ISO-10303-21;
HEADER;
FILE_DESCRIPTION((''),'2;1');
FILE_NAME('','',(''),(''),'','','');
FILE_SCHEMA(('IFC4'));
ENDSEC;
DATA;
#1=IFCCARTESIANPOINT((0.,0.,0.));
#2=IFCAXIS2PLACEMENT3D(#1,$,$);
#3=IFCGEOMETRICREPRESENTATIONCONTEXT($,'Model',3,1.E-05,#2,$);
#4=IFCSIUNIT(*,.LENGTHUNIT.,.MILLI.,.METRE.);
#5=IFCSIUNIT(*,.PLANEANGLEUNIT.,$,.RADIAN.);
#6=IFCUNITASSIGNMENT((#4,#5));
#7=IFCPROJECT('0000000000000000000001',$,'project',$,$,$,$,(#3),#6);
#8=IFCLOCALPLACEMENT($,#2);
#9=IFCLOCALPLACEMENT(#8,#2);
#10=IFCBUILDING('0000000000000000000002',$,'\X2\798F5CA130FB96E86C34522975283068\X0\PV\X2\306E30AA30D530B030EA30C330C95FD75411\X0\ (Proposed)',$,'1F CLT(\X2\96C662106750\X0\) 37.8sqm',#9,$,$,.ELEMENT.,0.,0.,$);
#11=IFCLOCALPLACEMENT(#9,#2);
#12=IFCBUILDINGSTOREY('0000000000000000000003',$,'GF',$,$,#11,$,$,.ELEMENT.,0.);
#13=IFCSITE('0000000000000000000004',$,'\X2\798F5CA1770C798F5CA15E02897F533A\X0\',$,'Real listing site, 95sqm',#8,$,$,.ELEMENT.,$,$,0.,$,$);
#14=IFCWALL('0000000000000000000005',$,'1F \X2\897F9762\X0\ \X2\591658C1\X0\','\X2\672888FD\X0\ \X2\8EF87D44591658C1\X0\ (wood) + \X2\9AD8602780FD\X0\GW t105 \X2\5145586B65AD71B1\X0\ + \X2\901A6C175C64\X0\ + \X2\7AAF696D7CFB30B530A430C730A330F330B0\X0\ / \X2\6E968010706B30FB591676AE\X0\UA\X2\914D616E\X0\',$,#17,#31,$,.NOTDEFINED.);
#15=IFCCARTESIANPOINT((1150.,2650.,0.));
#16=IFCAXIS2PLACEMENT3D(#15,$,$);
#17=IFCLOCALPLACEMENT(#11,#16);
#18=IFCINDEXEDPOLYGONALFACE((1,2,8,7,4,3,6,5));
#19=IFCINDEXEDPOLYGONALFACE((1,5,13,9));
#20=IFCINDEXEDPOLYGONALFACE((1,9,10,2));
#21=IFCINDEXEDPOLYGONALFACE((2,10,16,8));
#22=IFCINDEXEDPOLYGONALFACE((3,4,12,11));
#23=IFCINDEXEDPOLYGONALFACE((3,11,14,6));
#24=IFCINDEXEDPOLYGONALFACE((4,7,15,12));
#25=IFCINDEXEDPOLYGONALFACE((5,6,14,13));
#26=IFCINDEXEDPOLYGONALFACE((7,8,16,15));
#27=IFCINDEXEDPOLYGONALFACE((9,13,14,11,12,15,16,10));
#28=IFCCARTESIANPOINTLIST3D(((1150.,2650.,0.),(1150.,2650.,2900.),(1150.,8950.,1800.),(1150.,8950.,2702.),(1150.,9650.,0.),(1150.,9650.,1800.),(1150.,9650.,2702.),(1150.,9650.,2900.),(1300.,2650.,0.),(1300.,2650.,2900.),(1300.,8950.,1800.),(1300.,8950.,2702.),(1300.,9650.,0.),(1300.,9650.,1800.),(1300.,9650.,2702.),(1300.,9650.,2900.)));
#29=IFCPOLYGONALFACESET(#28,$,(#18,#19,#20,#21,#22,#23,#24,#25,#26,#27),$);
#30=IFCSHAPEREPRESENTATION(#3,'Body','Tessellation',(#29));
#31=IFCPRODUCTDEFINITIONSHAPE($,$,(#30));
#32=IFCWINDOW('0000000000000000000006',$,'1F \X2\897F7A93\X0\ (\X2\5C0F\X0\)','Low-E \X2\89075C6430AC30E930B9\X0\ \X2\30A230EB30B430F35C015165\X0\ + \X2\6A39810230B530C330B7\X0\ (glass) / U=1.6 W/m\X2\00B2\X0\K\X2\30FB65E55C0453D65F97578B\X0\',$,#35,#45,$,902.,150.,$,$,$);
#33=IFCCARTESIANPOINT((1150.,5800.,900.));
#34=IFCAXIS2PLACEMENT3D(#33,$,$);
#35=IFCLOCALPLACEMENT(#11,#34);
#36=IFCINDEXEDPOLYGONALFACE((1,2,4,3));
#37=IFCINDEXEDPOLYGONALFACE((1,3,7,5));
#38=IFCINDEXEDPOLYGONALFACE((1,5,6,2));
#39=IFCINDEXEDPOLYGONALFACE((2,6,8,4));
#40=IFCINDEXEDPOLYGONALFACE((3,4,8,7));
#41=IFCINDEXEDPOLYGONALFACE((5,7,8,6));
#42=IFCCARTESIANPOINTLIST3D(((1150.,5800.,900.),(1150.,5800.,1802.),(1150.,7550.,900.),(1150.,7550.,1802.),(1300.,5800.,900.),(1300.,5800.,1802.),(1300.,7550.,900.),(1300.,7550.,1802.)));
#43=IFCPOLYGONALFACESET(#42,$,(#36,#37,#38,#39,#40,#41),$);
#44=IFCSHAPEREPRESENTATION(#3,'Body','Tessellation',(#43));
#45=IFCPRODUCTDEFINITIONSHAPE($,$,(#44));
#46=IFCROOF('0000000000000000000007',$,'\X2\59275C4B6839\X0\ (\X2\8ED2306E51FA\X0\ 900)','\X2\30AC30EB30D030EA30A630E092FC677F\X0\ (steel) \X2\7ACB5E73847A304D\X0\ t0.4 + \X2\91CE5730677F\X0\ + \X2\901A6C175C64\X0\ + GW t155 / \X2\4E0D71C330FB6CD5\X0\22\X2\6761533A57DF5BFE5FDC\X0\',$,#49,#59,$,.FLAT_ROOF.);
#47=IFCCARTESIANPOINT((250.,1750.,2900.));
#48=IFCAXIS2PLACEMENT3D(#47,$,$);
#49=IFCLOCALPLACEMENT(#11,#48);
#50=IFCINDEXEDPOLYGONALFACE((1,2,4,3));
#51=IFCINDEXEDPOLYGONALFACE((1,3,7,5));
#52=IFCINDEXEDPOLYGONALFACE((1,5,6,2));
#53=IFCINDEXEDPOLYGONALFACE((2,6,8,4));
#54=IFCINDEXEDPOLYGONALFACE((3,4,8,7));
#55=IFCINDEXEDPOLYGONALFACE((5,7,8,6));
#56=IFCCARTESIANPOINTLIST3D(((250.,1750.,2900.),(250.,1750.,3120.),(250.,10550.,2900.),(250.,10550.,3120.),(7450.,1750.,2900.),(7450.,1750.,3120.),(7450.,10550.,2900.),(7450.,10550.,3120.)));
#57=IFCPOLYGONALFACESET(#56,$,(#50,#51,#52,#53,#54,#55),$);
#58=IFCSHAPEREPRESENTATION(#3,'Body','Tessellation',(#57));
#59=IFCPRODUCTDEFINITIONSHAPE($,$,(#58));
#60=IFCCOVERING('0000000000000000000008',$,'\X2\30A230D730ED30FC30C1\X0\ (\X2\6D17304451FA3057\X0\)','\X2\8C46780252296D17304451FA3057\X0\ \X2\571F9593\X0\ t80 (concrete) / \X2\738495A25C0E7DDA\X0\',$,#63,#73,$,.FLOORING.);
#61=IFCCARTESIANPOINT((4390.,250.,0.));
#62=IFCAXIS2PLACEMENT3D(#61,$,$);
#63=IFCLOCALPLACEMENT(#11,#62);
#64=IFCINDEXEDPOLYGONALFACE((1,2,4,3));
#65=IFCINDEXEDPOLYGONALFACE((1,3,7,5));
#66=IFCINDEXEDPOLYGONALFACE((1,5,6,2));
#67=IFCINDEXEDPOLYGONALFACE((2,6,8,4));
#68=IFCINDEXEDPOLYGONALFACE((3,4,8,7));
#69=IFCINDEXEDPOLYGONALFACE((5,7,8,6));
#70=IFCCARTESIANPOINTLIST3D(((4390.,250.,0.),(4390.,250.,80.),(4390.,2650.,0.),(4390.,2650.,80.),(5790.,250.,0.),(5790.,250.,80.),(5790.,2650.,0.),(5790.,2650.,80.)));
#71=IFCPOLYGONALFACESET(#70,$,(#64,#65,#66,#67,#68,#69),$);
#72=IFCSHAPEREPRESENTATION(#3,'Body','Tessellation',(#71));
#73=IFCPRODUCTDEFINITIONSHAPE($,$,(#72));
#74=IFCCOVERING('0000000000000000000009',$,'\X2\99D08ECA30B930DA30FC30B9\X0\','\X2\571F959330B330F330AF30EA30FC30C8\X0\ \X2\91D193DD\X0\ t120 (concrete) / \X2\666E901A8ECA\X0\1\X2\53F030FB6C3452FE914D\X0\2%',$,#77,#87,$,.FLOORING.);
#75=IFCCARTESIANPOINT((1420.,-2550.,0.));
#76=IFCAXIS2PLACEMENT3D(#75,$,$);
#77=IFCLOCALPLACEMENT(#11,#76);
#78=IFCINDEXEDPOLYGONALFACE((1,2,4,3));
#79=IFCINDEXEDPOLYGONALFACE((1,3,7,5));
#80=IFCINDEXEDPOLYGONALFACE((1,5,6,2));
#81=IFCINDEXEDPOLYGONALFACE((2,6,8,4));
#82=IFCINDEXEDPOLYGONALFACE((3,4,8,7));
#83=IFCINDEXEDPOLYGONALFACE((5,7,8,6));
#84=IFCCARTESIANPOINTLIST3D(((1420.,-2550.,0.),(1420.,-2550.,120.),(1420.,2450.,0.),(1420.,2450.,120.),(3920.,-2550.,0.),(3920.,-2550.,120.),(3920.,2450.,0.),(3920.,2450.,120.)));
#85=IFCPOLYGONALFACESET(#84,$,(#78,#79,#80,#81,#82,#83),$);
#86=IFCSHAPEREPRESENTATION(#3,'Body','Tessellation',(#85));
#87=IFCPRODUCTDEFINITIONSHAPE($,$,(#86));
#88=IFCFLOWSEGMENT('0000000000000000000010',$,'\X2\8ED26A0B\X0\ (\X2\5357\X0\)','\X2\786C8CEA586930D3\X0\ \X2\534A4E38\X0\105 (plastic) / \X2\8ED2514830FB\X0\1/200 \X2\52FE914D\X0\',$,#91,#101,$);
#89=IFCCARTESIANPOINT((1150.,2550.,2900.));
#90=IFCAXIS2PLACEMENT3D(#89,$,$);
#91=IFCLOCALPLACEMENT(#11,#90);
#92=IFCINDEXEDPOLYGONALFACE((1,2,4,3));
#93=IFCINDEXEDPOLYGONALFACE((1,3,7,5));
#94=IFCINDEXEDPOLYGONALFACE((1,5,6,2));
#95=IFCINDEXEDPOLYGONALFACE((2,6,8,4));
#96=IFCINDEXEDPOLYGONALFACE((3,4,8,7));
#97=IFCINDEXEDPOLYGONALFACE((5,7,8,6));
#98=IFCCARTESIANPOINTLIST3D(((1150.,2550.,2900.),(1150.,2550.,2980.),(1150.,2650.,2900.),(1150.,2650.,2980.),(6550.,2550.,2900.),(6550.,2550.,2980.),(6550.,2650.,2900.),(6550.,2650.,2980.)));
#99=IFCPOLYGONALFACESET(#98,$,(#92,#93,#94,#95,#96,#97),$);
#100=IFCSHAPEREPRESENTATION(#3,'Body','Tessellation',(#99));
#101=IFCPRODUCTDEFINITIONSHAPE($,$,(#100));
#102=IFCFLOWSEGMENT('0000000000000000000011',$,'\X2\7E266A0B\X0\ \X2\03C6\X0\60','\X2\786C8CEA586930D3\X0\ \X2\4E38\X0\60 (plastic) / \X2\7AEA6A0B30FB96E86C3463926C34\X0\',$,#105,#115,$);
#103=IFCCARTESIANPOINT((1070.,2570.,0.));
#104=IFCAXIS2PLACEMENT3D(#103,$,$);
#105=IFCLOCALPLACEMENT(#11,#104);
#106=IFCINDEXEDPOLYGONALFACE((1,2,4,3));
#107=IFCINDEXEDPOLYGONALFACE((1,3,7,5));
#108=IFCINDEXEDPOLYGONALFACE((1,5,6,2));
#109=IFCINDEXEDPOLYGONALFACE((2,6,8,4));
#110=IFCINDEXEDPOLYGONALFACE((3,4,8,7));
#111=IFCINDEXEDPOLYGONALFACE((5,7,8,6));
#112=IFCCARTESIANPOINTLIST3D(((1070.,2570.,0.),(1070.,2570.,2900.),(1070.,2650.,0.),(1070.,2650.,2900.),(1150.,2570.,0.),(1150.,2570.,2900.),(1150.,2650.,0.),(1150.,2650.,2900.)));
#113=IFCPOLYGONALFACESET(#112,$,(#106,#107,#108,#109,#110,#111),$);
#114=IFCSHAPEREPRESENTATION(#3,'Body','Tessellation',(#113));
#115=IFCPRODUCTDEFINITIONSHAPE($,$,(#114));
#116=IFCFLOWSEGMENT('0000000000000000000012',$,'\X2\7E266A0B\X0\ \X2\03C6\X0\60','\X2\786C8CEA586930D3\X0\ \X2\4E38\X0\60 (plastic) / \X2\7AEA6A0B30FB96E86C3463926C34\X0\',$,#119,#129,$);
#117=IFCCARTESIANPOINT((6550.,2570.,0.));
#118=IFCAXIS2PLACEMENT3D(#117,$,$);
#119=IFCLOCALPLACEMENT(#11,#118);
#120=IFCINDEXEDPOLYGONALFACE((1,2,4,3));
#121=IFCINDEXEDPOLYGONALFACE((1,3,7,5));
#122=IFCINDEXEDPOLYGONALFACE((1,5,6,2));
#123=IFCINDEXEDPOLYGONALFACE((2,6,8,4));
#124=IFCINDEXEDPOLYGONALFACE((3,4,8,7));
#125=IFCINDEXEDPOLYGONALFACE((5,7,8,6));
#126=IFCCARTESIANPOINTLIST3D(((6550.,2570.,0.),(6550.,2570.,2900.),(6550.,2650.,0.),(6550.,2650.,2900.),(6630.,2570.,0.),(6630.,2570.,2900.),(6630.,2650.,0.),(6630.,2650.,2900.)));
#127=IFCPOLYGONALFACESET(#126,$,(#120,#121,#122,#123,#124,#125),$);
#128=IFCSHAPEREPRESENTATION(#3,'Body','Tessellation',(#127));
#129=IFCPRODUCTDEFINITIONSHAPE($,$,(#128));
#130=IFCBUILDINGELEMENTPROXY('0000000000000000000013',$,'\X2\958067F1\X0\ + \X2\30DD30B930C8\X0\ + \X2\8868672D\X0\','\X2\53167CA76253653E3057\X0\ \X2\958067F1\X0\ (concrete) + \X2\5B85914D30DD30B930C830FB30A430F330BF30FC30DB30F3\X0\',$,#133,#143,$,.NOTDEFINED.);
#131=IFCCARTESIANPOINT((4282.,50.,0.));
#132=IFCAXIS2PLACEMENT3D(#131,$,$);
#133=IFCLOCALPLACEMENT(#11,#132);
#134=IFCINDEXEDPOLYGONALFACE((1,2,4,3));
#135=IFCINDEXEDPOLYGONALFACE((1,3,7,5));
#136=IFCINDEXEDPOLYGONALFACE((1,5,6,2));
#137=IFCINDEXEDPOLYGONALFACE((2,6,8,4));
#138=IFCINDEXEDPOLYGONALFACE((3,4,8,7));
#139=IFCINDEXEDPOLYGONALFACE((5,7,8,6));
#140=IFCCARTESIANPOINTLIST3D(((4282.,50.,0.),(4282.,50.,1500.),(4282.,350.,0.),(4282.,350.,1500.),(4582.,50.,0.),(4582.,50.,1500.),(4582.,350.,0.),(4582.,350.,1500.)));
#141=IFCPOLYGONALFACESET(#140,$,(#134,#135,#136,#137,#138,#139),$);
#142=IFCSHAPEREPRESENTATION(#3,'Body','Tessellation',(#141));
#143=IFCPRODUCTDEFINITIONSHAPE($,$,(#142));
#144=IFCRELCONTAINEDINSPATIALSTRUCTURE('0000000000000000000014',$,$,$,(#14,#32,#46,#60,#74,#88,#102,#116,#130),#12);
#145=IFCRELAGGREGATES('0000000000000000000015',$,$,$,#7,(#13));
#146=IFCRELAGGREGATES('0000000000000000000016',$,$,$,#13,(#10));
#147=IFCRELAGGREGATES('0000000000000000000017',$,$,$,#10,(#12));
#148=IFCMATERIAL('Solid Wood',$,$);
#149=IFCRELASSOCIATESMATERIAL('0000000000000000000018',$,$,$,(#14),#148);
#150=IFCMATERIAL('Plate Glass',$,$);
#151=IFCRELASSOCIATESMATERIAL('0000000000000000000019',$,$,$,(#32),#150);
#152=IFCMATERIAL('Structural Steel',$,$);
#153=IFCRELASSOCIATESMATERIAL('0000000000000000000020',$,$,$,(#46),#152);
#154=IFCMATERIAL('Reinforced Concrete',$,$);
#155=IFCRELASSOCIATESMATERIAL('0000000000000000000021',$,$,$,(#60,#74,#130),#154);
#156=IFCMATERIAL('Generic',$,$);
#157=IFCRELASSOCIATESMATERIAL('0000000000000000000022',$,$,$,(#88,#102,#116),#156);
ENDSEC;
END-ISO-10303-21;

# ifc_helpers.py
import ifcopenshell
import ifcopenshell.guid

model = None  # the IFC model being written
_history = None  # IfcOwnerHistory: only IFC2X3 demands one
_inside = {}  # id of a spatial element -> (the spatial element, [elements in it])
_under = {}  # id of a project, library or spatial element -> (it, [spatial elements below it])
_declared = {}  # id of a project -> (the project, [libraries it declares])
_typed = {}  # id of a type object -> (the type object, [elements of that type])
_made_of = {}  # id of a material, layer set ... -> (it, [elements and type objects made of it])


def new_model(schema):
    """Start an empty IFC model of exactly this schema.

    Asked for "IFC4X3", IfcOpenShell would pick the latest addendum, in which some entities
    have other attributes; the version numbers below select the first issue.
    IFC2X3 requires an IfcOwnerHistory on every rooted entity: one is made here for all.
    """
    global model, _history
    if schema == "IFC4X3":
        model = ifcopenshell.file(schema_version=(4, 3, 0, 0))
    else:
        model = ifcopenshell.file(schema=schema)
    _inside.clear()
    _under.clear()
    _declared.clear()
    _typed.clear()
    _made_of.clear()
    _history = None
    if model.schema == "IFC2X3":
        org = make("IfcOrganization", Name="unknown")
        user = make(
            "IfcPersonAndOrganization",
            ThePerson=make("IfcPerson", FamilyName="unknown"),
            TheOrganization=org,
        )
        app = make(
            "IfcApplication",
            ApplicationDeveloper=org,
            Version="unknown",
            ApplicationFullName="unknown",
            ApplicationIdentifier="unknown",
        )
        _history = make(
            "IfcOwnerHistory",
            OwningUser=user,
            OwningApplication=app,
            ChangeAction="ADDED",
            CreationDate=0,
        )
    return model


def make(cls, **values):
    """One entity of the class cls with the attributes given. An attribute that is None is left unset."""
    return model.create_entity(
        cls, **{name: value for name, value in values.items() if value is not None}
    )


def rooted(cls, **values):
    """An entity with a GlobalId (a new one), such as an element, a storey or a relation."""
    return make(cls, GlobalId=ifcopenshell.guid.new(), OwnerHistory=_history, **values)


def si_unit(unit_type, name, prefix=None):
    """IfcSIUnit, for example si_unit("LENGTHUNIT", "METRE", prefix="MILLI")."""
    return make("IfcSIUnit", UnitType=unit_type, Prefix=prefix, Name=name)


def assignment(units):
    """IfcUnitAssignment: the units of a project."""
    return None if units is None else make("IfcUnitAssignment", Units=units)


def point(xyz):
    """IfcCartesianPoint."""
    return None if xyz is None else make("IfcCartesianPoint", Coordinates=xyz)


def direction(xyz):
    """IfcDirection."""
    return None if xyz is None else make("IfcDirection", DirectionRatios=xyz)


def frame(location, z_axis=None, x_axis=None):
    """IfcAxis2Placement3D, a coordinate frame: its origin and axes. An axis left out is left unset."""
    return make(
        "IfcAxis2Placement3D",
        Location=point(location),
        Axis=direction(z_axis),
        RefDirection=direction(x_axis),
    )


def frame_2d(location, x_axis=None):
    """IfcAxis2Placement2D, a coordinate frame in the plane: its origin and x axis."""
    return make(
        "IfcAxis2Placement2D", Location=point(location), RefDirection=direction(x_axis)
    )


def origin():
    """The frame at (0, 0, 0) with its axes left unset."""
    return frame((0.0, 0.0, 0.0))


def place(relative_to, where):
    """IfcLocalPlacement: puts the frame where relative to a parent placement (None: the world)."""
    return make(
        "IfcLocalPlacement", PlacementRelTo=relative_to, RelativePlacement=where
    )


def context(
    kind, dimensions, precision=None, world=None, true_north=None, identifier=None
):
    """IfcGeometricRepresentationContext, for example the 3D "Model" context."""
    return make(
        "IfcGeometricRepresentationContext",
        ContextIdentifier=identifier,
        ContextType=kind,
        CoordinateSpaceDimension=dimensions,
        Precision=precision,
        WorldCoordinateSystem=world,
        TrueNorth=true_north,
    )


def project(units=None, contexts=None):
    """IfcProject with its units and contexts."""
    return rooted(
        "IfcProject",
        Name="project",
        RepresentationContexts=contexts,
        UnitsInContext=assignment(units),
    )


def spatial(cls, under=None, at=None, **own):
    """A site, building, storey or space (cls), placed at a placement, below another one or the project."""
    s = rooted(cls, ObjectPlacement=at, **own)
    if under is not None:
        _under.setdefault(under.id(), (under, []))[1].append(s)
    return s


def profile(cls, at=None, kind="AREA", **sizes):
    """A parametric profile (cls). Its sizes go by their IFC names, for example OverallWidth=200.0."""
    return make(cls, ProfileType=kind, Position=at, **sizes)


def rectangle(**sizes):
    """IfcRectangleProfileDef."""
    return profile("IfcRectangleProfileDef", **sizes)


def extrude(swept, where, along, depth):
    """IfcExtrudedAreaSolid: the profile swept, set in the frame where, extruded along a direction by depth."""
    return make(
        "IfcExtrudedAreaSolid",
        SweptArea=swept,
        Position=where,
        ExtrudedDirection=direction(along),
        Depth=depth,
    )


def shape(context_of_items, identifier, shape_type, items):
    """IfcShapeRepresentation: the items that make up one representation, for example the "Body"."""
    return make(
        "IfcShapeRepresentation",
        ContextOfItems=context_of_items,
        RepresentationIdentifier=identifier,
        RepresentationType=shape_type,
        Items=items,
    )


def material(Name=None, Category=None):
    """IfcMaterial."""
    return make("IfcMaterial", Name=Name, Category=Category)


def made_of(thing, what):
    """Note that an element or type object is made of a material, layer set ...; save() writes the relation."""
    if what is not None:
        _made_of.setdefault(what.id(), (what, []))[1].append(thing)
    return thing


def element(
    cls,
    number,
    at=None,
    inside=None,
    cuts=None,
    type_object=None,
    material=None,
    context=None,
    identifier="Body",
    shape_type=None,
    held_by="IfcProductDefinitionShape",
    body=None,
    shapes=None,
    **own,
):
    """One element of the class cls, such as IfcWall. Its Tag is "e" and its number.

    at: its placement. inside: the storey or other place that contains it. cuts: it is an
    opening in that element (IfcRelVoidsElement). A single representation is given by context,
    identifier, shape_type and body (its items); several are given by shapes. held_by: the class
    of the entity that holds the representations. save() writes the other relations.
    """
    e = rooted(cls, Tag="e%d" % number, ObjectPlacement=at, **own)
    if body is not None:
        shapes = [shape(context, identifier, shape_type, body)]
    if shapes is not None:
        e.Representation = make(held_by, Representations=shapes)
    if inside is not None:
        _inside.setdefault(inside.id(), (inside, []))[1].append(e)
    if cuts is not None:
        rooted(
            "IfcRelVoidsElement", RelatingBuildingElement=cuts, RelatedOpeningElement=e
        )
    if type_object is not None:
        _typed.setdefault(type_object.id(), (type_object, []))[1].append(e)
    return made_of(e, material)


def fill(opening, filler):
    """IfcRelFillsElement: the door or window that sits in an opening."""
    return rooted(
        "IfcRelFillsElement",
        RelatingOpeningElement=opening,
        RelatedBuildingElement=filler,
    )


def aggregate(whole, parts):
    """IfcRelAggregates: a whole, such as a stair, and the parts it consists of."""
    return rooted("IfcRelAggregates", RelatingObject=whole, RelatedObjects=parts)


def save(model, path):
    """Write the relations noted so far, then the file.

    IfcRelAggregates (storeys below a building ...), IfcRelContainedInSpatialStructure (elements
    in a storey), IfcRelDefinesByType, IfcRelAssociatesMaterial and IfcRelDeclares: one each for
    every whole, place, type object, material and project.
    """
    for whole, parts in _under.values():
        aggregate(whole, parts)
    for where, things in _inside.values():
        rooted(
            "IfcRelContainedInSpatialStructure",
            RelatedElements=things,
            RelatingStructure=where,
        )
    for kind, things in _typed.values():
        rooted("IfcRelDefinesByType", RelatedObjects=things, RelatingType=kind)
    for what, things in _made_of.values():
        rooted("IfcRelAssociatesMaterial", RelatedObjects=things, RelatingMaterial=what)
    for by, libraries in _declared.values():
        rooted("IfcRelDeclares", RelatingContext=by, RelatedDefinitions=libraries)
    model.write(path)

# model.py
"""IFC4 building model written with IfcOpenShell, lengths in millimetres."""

from ifc_helpers import new_model, si_unit, frame, frame_2d, origin, place, context, project, spatial, rectangle, extrude, material, element, fill, save


model = new_model("IFC4")

# Units and contexts
model_context = context("Model", 3, precision=1e-05, world=origin())
ifc_project = project(units=[si_unit("LENGTHUNIT", "METRE", prefix="MILLI"), si_unit("PLANEANGLEUNIT", "RADIAN")], contexts=[model_context])

# Site, building, storey
site_placement = place(None, origin())
site = spatial("IfcSite", under=ifc_project, at=site_placement, Name="福岡県福岡市西区", ObjectType="Real listing site, 95sqm", CompositionType="ELEMENT", RefElevation=0.0)
building_placement = place(site_placement, origin())
building = spatial("IfcBuilding", under=site, at=building_placement, Name="福岡・雨水利用とPVのオフグリッド志向 (Proposed)", ObjectType="1F CLT(集成材) 37.8sqm", CompositionType="ELEMENT", ElevationOfRefHeight=0.0, ElevationOfTerrain=0.0)
storey_placement = place(building_placement, origin())
storey = spatial("IfcBuildingStorey", under=building, at=storey_placement, Name="GF", CompositionType="ELEMENT", Elevation=0.0)

# Shared definitions
ifc_material_1 = material(Name="Solid Wood")

# Shared definitions
ifc_material_2 = material(Name="Reinforced Concrete")

# Shared definitions
ifc_material_3 = material(Name="Plate Glass")

# Wall, opening, window
wall_1_placement = place(storey_placement, frame((1150.0, 2650.0, 0.0)))
wall_1 = element("IfcWall", 1, at=wall_1_placement, inside=storey, material=ifc_material_1, Name="1F 西面 外壁", Description="木製 軸組外壁 (wood) + 高性能GW t105 充填断熱 + 通気層 + 窯業系サイディング / 準耐火・外皮UA配慮", PredefinedType="NOTDEFINED", context=model_context, shape_type="SweptSolid", body=[
    extrude(rectangle(XDim=150.0, YDim=7000.0, at=frame_2d((75.0, 3500.0))), frame((1150.0, 2650.0, 0.0)), (0.0, 0.0, 1.0), 2900.0),
])
opening_1_placement = place(storey_placement, frame((1150.0, 5800.0, 900.0)))
opening_1 = element("IfcOpeningElement", 2, at=opening_1_placement, cuts=wall_1, PredefinedType="NOTDEFINED", context=model_context, shape_type="SweptSolid", body=[
    extrude(rectangle(XDim=150.0, YDim=1750.0, at=frame_2d((75.0, 875.0))), frame((1150.0, 5800.0, 900.0)), (0.0, 0.0, 1.0), 902.0),
])
window_1_placement = place(storey_placement, frame((1150.0, 5800.0, 900.0)))
window_1 = element("IfcWindow", 3, at=window_1_placement, inside=storey, material=ifc_material_3, Name="1F 西窓 (小)", Description="Low-E 複層ガラス アルゴン封入 + 樹脂サッシ (glass) / U=1.6 W/m²K・日射取得型", OverallHeight=902.0, OverallWidth=150.0, context=model_context, shape_type="SweptSolid", body=[
    extrude(rectangle(XDim=150.0, YDim=1750.0, at=frame_2d((75.0, 875.0))), frame((1150.0, 5800.0, 900.0)), (0.0, 0.0, 1.0), 902.0),
])
fill(opening_1, window_1)

# Roof
ifc_material_4 = material(Name="Structural Steel")
roof_placement = place(storey_placement, frame((250.0, 1750.0, 2900.0)))
element("IfcRoof", 4, at=roof_placement, inside=storey, material=ifc_material_4, Name="大屋根 (軒の出 900)", Description="ガルバリウム鋼板 (steel) 立平葺き t0.4 + 野地板 + 通気層 + GW t155 / 不燃・法22条区域対応", PredefinedType="FLAT_ROOF", context=model_context, shape_type="SweptSolid", body=[
    extrude(rectangle(XDim=7200.0, YDim=8800.0, at=frame_2d((3600.0, 4400.0))), frame((250.0, 1750.0, 2900.0)), (0.0, 0.0, 1.0), 220.0),
])

# Coverings
covering_1_placement = place(storey_placement, frame((4390.0, 250.0, 0.0)))
element("IfcCovering", 5, at=covering_1_placement, inside=storey, material=ifc_material_2, Name="アプローチ (洗い出し)", Description="豆砂利洗い出し 土間 t80 (concrete) / 玄関導線", PredefinedType="FLOORING", context=model_context, shape_type="SweptSolid", body=[
    extrude(rectangle(XDim=1400.0, YDim=2400.0, at=frame_2d((700.0, 1200.0))), frame((4390.0, 250.0, 0.0)), (0.0, 0.0, 1.0), 80.0),
])
covering_2_placement = place(storey_placement, frame((1420.0, -2550.0, 0.0)))
element("IfcCovering", 6, at=covering_2_placement, inside=storey, material=ifc_material_2, Name="駐車スペース", Description="土間コンクリート 金鏝 t120 (concrete) / 普通車1台・水勾配2%", PredefinedType="FLOORING", context=model_context, shape_type="SweptSolid", body=[
    extrude(rectangle(XDim=2500.0, YDim=5000.0, at=frame_2d((1250.0, 2500.0))), frame((1420.0, -2550.0, 0.0)), (0.0, 0.0, 1.0), 120.0),
])

# Flow segments
ifc_material_5 = material(Name="Generic")
flow_segment_1_placement = place(storey_placement, frame((1150.0, 2550.0, 2900.0)))
element("IfcFlowSegment", 7, at=flow_segment_1_placement, inside=storey, material=ifc_material_5, Name="軒樋 (南)", Description="硬質塩ビ 半丸105 (plastic) / 軒先・1/200 勾配", context=model_context, shape_type="SweptSolid", body=[
    extrude(rectangle(XDim=5400.0, YDim=100.0, at=frame_2d((2700.0, 50.0))), frame((1150.0, 2550.0, 2900.0)), (0.0, 0.0, 1.0), 80.0),
])
flow_segment_2_placement = place(storey_placement, frame((1070.0, 2570.0, 0.0)))
element("IfcFlowSegment", 8, at=flow_segment_2_placement, inside=storey, material=ifc_material_5, Name="縦樋 φ60", Description="硬質塩ビ 丸60 (plastic) / 竪樋・雨水排水", context=model_context, shape_type="SweptSolid", body=[
    extrude(rectangle(XDim=80.0, YDim=80.0, at=frame_2d((40.0, 40.0))), frame((1070.0, 2570.0, 0.0)), (0.0, 0.0, 1.0), 2900.0),
])
flow_segment_3_placement = place(storey_placement, frame((6550.0, 2570.0, 0.0)))
element("IfcFlowSegment", 9, at=flow_segment_3_placement, inside=storey, material=ifc_material_5, Name="縦樋 φ60", Description="硬質塩ビ 丸60 (plastic) / 竪樋・雨水排水", context=model_context, shape_type="SweptSolid", body=[
    extrude(rectangle(XDim=80.0, YDim=80.0, at=frame_2d((40.0, 40.0))), frame((6550.0, 2570.0, 0.0)), (0.0, 0.0, 1.0), 2900.0),
])

# Building element proxy
proxy_placement = place(storey_placement, frame((4282.0, 50.0, 0.0)))
element("IfcBuildingElementProxy", 10, at=proxy_placement, inside=storey, material=ifc_material_2, Name="門柱 + ポスト + 表札", Description="化粧打放し 門柱 (concrete) + 宅配ポスト・インターホン", PredefinedType="NOTDEFINED", context=model_context, shape_type="SweptSolid", body=[
    extrude(rectangle(XDim=300.0, YDim=300.0, at=frame_2d((150.0, 150.0))), frame((4282.0, 50.0, 0.0)), (0.0, 0.0, 1.0), 1500.0),
])

save(model, "model.ifc")
